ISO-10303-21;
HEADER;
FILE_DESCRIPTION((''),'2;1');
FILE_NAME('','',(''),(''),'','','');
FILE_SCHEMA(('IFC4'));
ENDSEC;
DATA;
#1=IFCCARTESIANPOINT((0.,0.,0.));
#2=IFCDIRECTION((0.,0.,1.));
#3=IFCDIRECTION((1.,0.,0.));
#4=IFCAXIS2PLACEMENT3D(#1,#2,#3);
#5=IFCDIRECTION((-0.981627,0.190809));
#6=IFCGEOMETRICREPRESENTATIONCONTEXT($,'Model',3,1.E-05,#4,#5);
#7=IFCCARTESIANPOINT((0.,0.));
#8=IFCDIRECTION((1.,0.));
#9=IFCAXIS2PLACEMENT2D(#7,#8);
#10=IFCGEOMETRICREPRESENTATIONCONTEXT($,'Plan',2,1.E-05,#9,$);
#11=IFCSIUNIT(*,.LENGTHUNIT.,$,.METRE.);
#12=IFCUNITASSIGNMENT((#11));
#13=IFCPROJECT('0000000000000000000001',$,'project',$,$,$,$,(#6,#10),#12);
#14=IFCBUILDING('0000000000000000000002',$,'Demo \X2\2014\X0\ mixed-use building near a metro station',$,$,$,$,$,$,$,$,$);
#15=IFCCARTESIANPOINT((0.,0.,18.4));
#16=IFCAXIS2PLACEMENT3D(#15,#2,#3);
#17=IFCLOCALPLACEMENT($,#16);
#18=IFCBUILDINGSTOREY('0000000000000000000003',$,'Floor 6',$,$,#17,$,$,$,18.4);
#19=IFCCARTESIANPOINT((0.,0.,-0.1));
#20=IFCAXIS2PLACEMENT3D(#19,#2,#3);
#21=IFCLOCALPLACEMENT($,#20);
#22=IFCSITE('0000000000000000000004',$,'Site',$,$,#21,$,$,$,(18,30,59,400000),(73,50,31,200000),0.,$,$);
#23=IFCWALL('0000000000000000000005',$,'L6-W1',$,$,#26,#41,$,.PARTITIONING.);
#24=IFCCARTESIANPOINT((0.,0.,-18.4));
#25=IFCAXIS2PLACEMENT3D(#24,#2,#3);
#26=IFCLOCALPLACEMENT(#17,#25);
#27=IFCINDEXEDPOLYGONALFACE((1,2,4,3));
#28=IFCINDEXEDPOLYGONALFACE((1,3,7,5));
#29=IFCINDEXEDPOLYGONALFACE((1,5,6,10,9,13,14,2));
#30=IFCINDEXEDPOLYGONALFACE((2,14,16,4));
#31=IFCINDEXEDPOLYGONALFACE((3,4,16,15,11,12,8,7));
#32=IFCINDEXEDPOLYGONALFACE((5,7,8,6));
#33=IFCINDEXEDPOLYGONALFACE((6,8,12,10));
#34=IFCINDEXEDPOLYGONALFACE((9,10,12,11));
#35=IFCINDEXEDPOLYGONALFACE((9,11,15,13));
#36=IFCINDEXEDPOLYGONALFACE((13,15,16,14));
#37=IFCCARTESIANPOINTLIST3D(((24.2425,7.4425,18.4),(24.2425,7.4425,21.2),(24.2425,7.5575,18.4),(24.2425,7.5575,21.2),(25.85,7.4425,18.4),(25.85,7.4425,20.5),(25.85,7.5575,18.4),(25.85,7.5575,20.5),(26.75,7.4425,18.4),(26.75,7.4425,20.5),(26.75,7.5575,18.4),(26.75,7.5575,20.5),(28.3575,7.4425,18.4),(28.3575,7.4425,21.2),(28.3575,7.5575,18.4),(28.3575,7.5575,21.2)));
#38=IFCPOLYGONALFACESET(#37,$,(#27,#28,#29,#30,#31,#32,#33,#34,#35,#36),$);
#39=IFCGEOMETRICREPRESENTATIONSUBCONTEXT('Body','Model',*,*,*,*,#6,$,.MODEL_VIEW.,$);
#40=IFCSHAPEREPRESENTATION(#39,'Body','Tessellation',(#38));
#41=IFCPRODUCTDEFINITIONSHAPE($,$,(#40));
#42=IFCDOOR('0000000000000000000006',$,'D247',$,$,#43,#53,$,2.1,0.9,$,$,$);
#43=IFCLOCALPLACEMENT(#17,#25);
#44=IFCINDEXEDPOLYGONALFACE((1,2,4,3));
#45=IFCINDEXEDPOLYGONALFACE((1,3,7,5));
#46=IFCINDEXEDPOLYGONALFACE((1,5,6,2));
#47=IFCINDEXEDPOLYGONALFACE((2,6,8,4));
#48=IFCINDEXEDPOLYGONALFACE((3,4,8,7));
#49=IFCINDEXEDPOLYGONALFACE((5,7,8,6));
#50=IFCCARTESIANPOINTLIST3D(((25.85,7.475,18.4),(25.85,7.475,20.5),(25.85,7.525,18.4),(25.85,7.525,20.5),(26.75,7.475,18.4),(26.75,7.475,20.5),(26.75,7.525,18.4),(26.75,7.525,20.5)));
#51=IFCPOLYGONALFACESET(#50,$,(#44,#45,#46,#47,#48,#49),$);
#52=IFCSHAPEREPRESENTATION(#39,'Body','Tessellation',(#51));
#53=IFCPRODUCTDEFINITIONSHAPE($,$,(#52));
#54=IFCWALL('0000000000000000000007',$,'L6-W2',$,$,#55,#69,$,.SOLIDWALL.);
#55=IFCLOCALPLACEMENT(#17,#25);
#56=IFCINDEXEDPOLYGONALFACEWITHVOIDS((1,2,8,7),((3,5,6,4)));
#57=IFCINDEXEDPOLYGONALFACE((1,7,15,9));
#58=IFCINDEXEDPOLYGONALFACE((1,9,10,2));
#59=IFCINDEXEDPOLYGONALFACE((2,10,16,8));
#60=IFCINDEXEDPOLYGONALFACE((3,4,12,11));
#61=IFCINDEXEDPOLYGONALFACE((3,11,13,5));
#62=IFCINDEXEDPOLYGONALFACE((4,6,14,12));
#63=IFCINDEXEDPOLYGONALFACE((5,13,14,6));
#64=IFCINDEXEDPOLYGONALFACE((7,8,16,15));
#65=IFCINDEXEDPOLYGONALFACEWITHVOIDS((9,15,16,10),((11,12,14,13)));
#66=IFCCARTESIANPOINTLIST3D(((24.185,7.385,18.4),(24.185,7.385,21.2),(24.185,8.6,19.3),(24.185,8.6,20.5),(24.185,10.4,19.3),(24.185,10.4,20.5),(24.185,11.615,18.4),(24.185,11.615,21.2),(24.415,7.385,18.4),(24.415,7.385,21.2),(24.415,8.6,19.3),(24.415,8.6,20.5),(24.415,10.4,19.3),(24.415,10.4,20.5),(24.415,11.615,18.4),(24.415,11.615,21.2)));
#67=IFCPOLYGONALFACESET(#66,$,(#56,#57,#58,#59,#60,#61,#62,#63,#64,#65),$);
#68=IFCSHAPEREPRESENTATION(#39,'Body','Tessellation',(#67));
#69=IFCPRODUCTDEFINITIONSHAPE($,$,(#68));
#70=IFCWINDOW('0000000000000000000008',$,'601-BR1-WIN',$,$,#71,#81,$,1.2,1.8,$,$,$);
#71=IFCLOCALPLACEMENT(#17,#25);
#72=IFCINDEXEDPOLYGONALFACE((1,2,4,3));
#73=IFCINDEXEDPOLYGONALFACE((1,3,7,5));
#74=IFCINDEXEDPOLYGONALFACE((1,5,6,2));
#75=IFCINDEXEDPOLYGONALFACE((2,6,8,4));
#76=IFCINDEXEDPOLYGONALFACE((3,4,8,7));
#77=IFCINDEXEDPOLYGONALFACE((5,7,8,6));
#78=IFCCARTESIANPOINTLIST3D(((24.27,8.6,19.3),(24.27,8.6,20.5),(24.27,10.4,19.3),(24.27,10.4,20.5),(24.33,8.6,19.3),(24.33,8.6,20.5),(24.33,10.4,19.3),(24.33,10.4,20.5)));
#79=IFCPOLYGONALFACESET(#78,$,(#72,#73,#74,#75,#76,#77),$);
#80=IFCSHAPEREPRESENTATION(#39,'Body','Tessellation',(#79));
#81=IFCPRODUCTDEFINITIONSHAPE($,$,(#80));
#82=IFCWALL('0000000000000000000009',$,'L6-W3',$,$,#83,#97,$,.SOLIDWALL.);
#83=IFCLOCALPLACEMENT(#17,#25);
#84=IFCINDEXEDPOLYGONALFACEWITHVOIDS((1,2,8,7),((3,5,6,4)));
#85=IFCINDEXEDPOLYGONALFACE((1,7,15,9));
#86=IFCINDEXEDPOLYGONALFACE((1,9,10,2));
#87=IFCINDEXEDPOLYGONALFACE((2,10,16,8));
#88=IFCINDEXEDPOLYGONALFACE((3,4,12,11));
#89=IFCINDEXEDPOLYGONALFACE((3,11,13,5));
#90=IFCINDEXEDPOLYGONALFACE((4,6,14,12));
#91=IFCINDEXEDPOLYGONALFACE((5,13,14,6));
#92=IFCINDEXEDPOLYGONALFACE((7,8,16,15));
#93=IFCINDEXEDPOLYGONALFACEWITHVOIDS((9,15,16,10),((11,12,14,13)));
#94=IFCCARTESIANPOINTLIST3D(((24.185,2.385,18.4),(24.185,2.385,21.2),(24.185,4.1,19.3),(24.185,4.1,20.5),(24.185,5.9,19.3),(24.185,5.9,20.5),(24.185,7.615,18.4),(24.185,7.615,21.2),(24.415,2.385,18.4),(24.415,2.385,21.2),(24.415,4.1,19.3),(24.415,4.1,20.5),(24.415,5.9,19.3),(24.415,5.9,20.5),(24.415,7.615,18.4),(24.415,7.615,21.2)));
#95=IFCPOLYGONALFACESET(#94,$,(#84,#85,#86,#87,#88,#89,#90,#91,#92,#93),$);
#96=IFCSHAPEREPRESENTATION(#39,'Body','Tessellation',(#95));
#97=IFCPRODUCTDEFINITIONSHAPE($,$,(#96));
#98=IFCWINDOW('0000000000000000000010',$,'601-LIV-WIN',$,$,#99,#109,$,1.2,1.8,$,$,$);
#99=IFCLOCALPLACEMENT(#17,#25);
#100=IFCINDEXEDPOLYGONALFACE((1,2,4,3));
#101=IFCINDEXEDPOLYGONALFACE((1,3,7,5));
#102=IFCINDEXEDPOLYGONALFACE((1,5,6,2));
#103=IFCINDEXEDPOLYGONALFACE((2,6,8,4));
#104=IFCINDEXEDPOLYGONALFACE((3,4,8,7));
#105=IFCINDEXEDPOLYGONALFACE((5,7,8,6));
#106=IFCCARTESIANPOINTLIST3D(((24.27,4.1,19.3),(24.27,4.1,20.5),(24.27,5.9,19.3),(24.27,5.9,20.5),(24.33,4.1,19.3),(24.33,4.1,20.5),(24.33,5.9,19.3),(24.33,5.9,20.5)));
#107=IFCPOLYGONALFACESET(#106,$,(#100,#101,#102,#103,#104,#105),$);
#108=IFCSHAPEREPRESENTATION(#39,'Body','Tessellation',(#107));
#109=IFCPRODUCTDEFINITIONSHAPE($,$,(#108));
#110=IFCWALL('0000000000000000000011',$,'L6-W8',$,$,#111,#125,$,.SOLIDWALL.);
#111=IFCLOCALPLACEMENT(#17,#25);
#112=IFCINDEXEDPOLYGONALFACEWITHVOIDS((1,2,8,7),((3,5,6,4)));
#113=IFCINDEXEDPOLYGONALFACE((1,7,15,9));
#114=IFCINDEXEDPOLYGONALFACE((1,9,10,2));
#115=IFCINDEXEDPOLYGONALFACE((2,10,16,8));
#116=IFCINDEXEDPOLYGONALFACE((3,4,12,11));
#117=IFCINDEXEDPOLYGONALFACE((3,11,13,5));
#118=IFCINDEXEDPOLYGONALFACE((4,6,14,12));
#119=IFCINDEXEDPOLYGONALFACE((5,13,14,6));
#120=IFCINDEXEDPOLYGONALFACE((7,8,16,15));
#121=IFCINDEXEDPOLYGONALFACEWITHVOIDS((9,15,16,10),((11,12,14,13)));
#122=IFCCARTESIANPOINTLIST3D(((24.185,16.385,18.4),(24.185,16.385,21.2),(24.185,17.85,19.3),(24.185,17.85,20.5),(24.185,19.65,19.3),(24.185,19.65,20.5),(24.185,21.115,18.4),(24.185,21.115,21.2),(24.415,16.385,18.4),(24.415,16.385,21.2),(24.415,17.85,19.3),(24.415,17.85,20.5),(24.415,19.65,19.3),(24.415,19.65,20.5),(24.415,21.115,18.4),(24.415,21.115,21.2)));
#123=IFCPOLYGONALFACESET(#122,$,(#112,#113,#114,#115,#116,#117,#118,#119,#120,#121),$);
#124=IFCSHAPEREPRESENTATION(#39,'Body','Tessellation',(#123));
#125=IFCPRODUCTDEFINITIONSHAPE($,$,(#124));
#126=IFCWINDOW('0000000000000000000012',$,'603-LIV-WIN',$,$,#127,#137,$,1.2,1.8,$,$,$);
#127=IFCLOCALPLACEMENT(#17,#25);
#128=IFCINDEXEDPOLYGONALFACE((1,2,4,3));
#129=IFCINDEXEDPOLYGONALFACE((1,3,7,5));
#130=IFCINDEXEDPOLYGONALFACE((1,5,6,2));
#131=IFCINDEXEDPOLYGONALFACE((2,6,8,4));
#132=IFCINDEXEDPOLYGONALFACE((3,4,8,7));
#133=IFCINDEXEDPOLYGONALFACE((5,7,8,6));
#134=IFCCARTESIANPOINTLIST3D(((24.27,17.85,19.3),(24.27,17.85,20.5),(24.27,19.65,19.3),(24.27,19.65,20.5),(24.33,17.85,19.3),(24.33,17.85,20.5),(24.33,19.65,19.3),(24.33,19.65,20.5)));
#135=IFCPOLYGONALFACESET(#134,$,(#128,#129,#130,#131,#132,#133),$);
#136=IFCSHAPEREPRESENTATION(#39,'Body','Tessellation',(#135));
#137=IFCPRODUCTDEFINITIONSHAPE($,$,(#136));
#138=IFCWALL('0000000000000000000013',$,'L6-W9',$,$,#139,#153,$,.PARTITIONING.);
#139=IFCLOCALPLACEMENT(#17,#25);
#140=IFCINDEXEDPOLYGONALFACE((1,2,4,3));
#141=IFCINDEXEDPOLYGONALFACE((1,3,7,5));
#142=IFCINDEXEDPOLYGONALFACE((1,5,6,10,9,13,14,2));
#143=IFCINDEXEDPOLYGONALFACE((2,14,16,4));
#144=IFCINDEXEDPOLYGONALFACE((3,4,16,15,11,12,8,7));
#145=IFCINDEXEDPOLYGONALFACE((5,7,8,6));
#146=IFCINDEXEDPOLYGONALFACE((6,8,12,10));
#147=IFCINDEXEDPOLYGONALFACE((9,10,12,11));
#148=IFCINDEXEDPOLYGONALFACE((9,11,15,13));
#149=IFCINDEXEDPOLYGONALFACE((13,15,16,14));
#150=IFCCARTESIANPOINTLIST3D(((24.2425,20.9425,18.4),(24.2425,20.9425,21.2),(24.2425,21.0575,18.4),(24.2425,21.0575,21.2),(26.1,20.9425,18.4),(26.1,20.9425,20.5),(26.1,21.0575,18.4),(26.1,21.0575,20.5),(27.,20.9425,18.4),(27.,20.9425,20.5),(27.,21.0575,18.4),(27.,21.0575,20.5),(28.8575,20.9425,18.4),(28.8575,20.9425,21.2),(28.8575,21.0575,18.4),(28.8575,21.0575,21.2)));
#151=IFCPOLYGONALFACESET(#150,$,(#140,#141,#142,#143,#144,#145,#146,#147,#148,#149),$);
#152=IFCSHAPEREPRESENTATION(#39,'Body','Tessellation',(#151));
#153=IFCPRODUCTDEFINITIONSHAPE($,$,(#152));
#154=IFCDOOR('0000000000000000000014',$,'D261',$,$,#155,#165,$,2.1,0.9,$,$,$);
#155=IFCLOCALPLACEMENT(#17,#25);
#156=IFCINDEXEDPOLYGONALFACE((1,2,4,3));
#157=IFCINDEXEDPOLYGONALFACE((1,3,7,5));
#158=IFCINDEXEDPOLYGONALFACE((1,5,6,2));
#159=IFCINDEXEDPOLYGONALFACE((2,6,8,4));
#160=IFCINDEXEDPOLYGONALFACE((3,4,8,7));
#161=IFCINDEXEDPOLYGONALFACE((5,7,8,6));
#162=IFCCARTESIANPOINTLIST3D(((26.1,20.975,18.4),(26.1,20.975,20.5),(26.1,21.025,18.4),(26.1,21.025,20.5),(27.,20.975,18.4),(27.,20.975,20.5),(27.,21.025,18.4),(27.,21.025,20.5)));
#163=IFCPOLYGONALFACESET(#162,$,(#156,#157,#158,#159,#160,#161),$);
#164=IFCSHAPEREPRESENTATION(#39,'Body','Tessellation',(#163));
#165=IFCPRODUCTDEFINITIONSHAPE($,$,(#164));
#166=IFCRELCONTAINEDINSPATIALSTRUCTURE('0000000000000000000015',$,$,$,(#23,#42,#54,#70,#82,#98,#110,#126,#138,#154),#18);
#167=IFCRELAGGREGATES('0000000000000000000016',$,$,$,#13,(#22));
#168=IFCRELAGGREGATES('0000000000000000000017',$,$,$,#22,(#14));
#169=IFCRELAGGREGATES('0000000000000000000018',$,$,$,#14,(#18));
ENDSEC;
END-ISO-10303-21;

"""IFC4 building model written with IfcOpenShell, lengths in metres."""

from ifc_helpers import new_model, si_unit, direction, frame, origin_with_axes, origin_2d_with_axis, place, context, subcontext, project, spatial, line, indexed_curve, outline, extrude, element, fill, save


model = new_model("IFC4")

# Units and contexts
model_context = context("Model", 3, precision=1e-05, world=origin_with_axes(), true_north=direction((-0.981627, 0.190809)))
plan_context = context("Plan", 2, precision=1e-05, world=origin_2d_with_axis())
body_context = subcontext(model_context, "Body", "Model", "MODEL_VIEW")
ifc_project = project(units=[si_unit("LENGTHUNIT", "METRE")], contexts=[model_context, plan_context])

# Site, building, storey
site_placement = place(None, frame((0.0, 0.0, -0.1), z_axis=(0.0, 0.0, 1.0), x_axis=(1.0, 0.0, 0.0)))
site = spatial("IfcSite", under=ifc_project, at=site_placement, Name="Site", RefLatitude=(18, 30, 59, 400000), RefLongitude=(73, 50, 31, 200000), RefElevation=0.0)
building = spatial("IfcBuilding", under=site, Name="Demo — mixed-use building near a metro station")
storey_placement = place(None, frame((0.0, 0.0, 18.4), z_axis=(0.0, 0.0, 1.0), x_axis=(1.0, 0.0, 0.0)))
storey = spatial("IfcBuildingStorey", under=building, at=storey_placement, Name="Floor 6", Elevation=18.4)

# Wall, opening, door
wall_1_placement = place(storey_placement, frame((0.0, 0.0, -18.4), z_axis=(0.0, 0.0, 1.0), x_axis=(1.0, 0.0, 0.0)))
wall_1 = element("IfcWall", 1, at=wall_1_placement, inside=storey, Name="L6-W1", PredefinedType="PARTITIONING", context=body_context, shape_type="SweptSolid", body=[
    extrude(outline(indexed_curve([(28.3575, 7.4425), (24.2425, 7.4425), (24.2425, 7.5575), (28.3575, 7.5575)], segments=[line(1, 2, 3, 4, 1)])), frame((0.0, 0.0, 18.4), z_axis=(0.0, 0.0, 1.0), x_axis=(1.0, 0.0, 0.0)), (0.0, 0.0, 1.0), 2.8),
])
opening_1_placement = place(wall_1_placement, origin_with_axes())
opening_1 = element("IfcOpeningElement", 2, at=opening_1_placement, cuts=wall_1, context=body_context, shape_type="SweptSolid", body=[
    extrude(outline(indexed_curve([(26.75, 7.3925), (25.85, 7.3925), (25.85, 7.6075), (26.75, 7.6075)], segments=[line(1, 2, 3, 4, 1)])), frame((0.0, 0.0, 18.4), z_axis=(0.0, 0.0, 1.0), x_axis=(1.0, 0.0, 0.0)), (0.0, 0.0, 1.0), 2.1),
])
door_1_placement = place(storey_placement, frame((0.0, 0.0, -18.4), z_axis=(0.0, 0.0, 1.0), x_axis=(1.0, 0.0, 0.0)))
door_1 = element("IfcDoor", 3, at=door_1_placement, inside=storey, Name="D247", OverallHeight=2.1, OverallWidth=0.9, context=body_context, shape_type="SweptSolid", body=[
    extrude(outline(indexed_curve([(26.75, 7.475), (25.85, 7.475), (25.85, 7.525), (26.75, 7.525)], segments=[line(1, 2, 3, 4, 1)])), frame((0.0, 0.0, 18.4), z_axis=(0.0, 0.0, 1.0), x_axis=(1.0, 0.0, 0.0)), (0.0, 0.0, 1.0), 2.1),
])
fill(opening_1, door_1)

# Walls, openings, windows
wall_2_placement = place(storey_placement, frame((0.0, 0.0, -18.4), z_axis=(0.0, 0.0, 1.0), x_axis=(1.0, 0.0, 0.0)))
wall_2 = element("IfcWall", 4, at=wall_2_placement, inside=storey, Name="L6-W2", PredefinedType="SOLIDWALL", context=body_context, shape_type="SweptSolid", body=[
    extrude(outline(indexed_curve([(24.415, 11.615), (24.415, 7.385), (24.185, 7.385), (24.185, 11.615)], segments=[line(1, 2, 3, 4, 1)])), frame((0.0, 0.0, 18.4), z_axis=(0.0, 0.0, 1.0), x_axis=(1.0, 0.0, 0.0)), (0.0, 0.0, 1.0), 2.8),
])
opening_2_placement = place(wall_2_placement, origin_with_axes())
opening_2 = element("IfcOpeningElement", 5, at=opening_2_placement, cuts=wall_2, context=body_context, shape_type="SweptSolid", body=[
    extrude(outline(indexed_curve([(24.465, 10.4), (24.465, 8.6), (24.135, 8.6), (24.135, 10.4)], segments=[line(1, 2, 3, 4, 1)])), frame((0.0, 0.0, 19.3), z_axis=(0.0, 0.0, 1.0), x_axis=(1.0, 0.0, 0.0)), (0.0, 0.0, 1.0), 1.2),
])
window_1_placement = place(storey_placement, frame((0.0, 0.0, -18.4), z_axis=(0.0, 0.0, 1.0), x_axis=(1.0, 0.0, 0.0)))
window_1 = element("IfcWindow", 6, at=window_1_placement, inside=storey, Name="601-BR1-WIN", OverallHeight=1.2, OverallWidth=1.8, context=body_context, shape_type="SweptSolid", body=[
    extrude(outline(indexed_curve([(24.33, 10.4), (24.33, 8.6), (24.27, 8.6), (24.27, 10.4)], segments=[line(1, 2, 3, 4, 1)])), frame((0.0, 0.0, 19.3), z_axis=(0.0, 0.0, 1.0), x_axis=(1.0, 0.0, 0.0)), (0.0, 0.0, 1.0), 1.2),
])
fill(opening_2, window_1)
wall_3_placement = place(storey_placement, frame((0.0, 0.0, -18.4), z_axis=(0.0, 0.0, 1.0), x_axis=(1.0, 0.0, 0.0)))
wall_3 = element("IfcWall", 7, at=wall_3_placement, inside=storey, Name="L6-W3", PredefinedType="SOLIDWALL", context=body_context, shape_type="SweptSolid", body=[
    extrude(outline(indexed_curve([(24.415, 7.615), (24.415, 2.385), (24.185, 2.385), (24.185, 7.615)], segments=[line(1, 2, 3, 4, 1)])), frame((0.0, 0.0, 18.4), z_axis=(0.0, 0.0, 1.0), x_axis=(1.0, 0.0, 0.0)), (0.0, 0.0, 1.0), 2.8),
])
opening_3_placement = place(wall_3_placement, origin_with_axes())
opening_3 = element("IfcOpeningElement", 8, at=opening_3_placement, cuts=wall_3, context=body_context, shape_type="SweptSolid", body=[
    extrude(outline(indexed_curve([(24.465, 5.9), (24.465, 4.1), (24.135, 4.1), (24.135, 5.9)], segments=[line(1, 2, 3, 4, 1)])), frame((0.0, 0.0, 19.3), z_axis=(0.0, 0.0, 1.0), x_axis=(1.0, 0.0, 0.0)), (0.0, 0.0, 1.0), 1.2),
])
window_2_placement = place(storey_placement, frame((0.0, 0.0, -18.4), z_axis=(0.0, 0.0, 1.0), x_axis=(1.0, 0.0, 0.0)))
window_2 = element("IfcWindow", 9, at=window_2_placement, inside=storey, Name="601-LIV-WIN", OverallHeight=1.2, OverallWidth=1.8, context=body_context, shape_type="SweptSolid", body=[
    extrude(outline(indexed_curve([(24.33, 5.9), (24.33, 4.1), (24.27, 4.1), (24.27, 5.9)], segments=[line(1, 2, 3, 4, 1)])), frame((0.0, 0.0, 19.3), z_axis=(0.0, 0.0, 1.0), x_axis=(1.0, 0.0, 0.0)), (0.0, 0.0, 1.0), 1.2),
])
fill(opening_3, window_2)

# Wall, opening, window
wall_4_placement = place(storey_placement, frame((0.0, 0.0, -18.4), z_axis=(0.0, 0.0, 1.0), x_axis=(1.0, 0.0, 0.0)))
wall_4 = element("IfcWall", 10, at=wall_4_placement, inside=storey, Name="L6-W8", PredefinedType="SOLIDWALL", context=body_context, shape_type="SweptSolid", body=[
    extrude(outline(indexed_curve([(24.415, 21.115), (24.415, 16.385), (24.185, 16.385), (24.185, 21.115)], segments=[line(1, 2, 3, 4, 1)])), frame((0.0, 0.0, 18.4), z_axis=(0.0, 0.0, 1.0), x_axis=(1.0, 0.0, 0.0)), (0.0, 0.0, 1.0), 2.8),
])
opening_4_placement = place(wall_4_placement, origin_with_axes())
opening_4 = element("IfcOpeningElement", 11, at=opening_4_placement, cuts=wall_4, context=body_context, shape_type="SweptSolid", body=[
    extrude(outline(indexed_curve([(24.465, 19.65), (24.465, 17.85), (24.135, 17.85), (24.135, 19.65)], segments=[line(1, 2, 3, 4, 1)])), frame((0.0, 0.0, 19.3), z_axis=(0.0, 0.0, 1.0), x_axis=(1.0, 0.0, 0.0)), (0.0, 0.0, 1.0), 1.2),
])
window_3_placement = place(storey_placement, frame((0.0, 0.0, -18.4), z_axis=(0.0, 0.0, 1.0), x_axis=(1.0, 0.0, 0.0)))
window_3 = element("IfcWindow", 12, at=window_3_placement, inside=storey, Name="603-LIV-WIN", OverallHeight=1.2, OverallWidth=1.8, context=body_context, shape_type="SweptSolid", body=[
    extrude(outline(indexed_curve([(24.33, 19.65), (24.33, 17.85), (24.27, 17.85), (24.27, 19.65)], segments=[line(1, 2, 3, 4, 1)])), frame((0.0, 0.0, 19.3), z_axis=(0.0, 0.0, 1.0), x_axis=(1.0, 0.0, 0.0)), (0.0, 0.0, 1.0), 1.2),
])
fill(opening_4, window_3)

# Wall, opening, door
wall_5_placement = place(storey_placement, frame((0.0, 0.0, -18.4), z_axis=(0.0, 0.0, 1.0), x_axis=(1.0, 0.0, 0.0)))
wall_5 = element("IfcWall", 13, at=wall_5_placement, inside=storey, Name="L6-W9", PredefinedType="PARTITIONING", context=body_context, shape_type="SweptSolid", body=[
    extrude(outline(indexed_curve([(28.8575, 20.9425), (24.2425, 20.9425), (24.2425, 21.0575), (28.8575, 21.0575)], segments=[line(1, 2, 3, 4, 1)])), frame((0.0, 0.0, 18.4), z_axis=(0.0, 0.0, 1.0), x_axis=(1.0, 0.0, 0.0)), (0.0, 0.0, 1.0), 2.8),
])
opening_5_placement = place(wall_5_placement, origin_with_axes())
opening_5 = element("IfcOpeningElement", 14, at=opening_5_placement, cuts=wall_5, context=body_context, shape_type="SweptSolid", body=[
    extrude(outline(indexed_curve([(27.0, 20.8925), (26.1, 20.8925), (26.1, 21.1075), (27.0, 21.1075)], segments=[line(1, 2, 3, 4, 1)])), frame((0.0, 0.0, 18.4), z_axis=(0.0, 0.0, 1.0), x_axis=(1.0, 0.0, 0.0)), (0.0, 0.0, 1.0), 2.1),
])
door_2_placement = place(storey_placement, frame((0.0, 0.0, -18.4), z_axis=(0.0, 0.0, 1.0), x_axis=(1.0, 0.0, 0.0)))
door_2 = element("IfcDoor", 15, at=door_2_placement, inside=storey, Name="D261", OverallHeight=2.1, OverallWidth=0.9, context=body_context, shape_type="SweptSolid", body=[
    extrude(outline(indexed_curve([(27.0, 20.975), (26.1, 20.975), (26.1, 21.025), (27.0, 21.025)], segments=[line(1, 2, 3, 4, 1)])), frame((0.0, 0.0, 18.4), z_axis=(0.0, 0.0, 1.0), x_axis=(1.0, 0.0, 0.0)), (0.0, 0.0, 1.0), 2.1),
])
fill(opening_5, door_2)

save(model, "model.ifc")
